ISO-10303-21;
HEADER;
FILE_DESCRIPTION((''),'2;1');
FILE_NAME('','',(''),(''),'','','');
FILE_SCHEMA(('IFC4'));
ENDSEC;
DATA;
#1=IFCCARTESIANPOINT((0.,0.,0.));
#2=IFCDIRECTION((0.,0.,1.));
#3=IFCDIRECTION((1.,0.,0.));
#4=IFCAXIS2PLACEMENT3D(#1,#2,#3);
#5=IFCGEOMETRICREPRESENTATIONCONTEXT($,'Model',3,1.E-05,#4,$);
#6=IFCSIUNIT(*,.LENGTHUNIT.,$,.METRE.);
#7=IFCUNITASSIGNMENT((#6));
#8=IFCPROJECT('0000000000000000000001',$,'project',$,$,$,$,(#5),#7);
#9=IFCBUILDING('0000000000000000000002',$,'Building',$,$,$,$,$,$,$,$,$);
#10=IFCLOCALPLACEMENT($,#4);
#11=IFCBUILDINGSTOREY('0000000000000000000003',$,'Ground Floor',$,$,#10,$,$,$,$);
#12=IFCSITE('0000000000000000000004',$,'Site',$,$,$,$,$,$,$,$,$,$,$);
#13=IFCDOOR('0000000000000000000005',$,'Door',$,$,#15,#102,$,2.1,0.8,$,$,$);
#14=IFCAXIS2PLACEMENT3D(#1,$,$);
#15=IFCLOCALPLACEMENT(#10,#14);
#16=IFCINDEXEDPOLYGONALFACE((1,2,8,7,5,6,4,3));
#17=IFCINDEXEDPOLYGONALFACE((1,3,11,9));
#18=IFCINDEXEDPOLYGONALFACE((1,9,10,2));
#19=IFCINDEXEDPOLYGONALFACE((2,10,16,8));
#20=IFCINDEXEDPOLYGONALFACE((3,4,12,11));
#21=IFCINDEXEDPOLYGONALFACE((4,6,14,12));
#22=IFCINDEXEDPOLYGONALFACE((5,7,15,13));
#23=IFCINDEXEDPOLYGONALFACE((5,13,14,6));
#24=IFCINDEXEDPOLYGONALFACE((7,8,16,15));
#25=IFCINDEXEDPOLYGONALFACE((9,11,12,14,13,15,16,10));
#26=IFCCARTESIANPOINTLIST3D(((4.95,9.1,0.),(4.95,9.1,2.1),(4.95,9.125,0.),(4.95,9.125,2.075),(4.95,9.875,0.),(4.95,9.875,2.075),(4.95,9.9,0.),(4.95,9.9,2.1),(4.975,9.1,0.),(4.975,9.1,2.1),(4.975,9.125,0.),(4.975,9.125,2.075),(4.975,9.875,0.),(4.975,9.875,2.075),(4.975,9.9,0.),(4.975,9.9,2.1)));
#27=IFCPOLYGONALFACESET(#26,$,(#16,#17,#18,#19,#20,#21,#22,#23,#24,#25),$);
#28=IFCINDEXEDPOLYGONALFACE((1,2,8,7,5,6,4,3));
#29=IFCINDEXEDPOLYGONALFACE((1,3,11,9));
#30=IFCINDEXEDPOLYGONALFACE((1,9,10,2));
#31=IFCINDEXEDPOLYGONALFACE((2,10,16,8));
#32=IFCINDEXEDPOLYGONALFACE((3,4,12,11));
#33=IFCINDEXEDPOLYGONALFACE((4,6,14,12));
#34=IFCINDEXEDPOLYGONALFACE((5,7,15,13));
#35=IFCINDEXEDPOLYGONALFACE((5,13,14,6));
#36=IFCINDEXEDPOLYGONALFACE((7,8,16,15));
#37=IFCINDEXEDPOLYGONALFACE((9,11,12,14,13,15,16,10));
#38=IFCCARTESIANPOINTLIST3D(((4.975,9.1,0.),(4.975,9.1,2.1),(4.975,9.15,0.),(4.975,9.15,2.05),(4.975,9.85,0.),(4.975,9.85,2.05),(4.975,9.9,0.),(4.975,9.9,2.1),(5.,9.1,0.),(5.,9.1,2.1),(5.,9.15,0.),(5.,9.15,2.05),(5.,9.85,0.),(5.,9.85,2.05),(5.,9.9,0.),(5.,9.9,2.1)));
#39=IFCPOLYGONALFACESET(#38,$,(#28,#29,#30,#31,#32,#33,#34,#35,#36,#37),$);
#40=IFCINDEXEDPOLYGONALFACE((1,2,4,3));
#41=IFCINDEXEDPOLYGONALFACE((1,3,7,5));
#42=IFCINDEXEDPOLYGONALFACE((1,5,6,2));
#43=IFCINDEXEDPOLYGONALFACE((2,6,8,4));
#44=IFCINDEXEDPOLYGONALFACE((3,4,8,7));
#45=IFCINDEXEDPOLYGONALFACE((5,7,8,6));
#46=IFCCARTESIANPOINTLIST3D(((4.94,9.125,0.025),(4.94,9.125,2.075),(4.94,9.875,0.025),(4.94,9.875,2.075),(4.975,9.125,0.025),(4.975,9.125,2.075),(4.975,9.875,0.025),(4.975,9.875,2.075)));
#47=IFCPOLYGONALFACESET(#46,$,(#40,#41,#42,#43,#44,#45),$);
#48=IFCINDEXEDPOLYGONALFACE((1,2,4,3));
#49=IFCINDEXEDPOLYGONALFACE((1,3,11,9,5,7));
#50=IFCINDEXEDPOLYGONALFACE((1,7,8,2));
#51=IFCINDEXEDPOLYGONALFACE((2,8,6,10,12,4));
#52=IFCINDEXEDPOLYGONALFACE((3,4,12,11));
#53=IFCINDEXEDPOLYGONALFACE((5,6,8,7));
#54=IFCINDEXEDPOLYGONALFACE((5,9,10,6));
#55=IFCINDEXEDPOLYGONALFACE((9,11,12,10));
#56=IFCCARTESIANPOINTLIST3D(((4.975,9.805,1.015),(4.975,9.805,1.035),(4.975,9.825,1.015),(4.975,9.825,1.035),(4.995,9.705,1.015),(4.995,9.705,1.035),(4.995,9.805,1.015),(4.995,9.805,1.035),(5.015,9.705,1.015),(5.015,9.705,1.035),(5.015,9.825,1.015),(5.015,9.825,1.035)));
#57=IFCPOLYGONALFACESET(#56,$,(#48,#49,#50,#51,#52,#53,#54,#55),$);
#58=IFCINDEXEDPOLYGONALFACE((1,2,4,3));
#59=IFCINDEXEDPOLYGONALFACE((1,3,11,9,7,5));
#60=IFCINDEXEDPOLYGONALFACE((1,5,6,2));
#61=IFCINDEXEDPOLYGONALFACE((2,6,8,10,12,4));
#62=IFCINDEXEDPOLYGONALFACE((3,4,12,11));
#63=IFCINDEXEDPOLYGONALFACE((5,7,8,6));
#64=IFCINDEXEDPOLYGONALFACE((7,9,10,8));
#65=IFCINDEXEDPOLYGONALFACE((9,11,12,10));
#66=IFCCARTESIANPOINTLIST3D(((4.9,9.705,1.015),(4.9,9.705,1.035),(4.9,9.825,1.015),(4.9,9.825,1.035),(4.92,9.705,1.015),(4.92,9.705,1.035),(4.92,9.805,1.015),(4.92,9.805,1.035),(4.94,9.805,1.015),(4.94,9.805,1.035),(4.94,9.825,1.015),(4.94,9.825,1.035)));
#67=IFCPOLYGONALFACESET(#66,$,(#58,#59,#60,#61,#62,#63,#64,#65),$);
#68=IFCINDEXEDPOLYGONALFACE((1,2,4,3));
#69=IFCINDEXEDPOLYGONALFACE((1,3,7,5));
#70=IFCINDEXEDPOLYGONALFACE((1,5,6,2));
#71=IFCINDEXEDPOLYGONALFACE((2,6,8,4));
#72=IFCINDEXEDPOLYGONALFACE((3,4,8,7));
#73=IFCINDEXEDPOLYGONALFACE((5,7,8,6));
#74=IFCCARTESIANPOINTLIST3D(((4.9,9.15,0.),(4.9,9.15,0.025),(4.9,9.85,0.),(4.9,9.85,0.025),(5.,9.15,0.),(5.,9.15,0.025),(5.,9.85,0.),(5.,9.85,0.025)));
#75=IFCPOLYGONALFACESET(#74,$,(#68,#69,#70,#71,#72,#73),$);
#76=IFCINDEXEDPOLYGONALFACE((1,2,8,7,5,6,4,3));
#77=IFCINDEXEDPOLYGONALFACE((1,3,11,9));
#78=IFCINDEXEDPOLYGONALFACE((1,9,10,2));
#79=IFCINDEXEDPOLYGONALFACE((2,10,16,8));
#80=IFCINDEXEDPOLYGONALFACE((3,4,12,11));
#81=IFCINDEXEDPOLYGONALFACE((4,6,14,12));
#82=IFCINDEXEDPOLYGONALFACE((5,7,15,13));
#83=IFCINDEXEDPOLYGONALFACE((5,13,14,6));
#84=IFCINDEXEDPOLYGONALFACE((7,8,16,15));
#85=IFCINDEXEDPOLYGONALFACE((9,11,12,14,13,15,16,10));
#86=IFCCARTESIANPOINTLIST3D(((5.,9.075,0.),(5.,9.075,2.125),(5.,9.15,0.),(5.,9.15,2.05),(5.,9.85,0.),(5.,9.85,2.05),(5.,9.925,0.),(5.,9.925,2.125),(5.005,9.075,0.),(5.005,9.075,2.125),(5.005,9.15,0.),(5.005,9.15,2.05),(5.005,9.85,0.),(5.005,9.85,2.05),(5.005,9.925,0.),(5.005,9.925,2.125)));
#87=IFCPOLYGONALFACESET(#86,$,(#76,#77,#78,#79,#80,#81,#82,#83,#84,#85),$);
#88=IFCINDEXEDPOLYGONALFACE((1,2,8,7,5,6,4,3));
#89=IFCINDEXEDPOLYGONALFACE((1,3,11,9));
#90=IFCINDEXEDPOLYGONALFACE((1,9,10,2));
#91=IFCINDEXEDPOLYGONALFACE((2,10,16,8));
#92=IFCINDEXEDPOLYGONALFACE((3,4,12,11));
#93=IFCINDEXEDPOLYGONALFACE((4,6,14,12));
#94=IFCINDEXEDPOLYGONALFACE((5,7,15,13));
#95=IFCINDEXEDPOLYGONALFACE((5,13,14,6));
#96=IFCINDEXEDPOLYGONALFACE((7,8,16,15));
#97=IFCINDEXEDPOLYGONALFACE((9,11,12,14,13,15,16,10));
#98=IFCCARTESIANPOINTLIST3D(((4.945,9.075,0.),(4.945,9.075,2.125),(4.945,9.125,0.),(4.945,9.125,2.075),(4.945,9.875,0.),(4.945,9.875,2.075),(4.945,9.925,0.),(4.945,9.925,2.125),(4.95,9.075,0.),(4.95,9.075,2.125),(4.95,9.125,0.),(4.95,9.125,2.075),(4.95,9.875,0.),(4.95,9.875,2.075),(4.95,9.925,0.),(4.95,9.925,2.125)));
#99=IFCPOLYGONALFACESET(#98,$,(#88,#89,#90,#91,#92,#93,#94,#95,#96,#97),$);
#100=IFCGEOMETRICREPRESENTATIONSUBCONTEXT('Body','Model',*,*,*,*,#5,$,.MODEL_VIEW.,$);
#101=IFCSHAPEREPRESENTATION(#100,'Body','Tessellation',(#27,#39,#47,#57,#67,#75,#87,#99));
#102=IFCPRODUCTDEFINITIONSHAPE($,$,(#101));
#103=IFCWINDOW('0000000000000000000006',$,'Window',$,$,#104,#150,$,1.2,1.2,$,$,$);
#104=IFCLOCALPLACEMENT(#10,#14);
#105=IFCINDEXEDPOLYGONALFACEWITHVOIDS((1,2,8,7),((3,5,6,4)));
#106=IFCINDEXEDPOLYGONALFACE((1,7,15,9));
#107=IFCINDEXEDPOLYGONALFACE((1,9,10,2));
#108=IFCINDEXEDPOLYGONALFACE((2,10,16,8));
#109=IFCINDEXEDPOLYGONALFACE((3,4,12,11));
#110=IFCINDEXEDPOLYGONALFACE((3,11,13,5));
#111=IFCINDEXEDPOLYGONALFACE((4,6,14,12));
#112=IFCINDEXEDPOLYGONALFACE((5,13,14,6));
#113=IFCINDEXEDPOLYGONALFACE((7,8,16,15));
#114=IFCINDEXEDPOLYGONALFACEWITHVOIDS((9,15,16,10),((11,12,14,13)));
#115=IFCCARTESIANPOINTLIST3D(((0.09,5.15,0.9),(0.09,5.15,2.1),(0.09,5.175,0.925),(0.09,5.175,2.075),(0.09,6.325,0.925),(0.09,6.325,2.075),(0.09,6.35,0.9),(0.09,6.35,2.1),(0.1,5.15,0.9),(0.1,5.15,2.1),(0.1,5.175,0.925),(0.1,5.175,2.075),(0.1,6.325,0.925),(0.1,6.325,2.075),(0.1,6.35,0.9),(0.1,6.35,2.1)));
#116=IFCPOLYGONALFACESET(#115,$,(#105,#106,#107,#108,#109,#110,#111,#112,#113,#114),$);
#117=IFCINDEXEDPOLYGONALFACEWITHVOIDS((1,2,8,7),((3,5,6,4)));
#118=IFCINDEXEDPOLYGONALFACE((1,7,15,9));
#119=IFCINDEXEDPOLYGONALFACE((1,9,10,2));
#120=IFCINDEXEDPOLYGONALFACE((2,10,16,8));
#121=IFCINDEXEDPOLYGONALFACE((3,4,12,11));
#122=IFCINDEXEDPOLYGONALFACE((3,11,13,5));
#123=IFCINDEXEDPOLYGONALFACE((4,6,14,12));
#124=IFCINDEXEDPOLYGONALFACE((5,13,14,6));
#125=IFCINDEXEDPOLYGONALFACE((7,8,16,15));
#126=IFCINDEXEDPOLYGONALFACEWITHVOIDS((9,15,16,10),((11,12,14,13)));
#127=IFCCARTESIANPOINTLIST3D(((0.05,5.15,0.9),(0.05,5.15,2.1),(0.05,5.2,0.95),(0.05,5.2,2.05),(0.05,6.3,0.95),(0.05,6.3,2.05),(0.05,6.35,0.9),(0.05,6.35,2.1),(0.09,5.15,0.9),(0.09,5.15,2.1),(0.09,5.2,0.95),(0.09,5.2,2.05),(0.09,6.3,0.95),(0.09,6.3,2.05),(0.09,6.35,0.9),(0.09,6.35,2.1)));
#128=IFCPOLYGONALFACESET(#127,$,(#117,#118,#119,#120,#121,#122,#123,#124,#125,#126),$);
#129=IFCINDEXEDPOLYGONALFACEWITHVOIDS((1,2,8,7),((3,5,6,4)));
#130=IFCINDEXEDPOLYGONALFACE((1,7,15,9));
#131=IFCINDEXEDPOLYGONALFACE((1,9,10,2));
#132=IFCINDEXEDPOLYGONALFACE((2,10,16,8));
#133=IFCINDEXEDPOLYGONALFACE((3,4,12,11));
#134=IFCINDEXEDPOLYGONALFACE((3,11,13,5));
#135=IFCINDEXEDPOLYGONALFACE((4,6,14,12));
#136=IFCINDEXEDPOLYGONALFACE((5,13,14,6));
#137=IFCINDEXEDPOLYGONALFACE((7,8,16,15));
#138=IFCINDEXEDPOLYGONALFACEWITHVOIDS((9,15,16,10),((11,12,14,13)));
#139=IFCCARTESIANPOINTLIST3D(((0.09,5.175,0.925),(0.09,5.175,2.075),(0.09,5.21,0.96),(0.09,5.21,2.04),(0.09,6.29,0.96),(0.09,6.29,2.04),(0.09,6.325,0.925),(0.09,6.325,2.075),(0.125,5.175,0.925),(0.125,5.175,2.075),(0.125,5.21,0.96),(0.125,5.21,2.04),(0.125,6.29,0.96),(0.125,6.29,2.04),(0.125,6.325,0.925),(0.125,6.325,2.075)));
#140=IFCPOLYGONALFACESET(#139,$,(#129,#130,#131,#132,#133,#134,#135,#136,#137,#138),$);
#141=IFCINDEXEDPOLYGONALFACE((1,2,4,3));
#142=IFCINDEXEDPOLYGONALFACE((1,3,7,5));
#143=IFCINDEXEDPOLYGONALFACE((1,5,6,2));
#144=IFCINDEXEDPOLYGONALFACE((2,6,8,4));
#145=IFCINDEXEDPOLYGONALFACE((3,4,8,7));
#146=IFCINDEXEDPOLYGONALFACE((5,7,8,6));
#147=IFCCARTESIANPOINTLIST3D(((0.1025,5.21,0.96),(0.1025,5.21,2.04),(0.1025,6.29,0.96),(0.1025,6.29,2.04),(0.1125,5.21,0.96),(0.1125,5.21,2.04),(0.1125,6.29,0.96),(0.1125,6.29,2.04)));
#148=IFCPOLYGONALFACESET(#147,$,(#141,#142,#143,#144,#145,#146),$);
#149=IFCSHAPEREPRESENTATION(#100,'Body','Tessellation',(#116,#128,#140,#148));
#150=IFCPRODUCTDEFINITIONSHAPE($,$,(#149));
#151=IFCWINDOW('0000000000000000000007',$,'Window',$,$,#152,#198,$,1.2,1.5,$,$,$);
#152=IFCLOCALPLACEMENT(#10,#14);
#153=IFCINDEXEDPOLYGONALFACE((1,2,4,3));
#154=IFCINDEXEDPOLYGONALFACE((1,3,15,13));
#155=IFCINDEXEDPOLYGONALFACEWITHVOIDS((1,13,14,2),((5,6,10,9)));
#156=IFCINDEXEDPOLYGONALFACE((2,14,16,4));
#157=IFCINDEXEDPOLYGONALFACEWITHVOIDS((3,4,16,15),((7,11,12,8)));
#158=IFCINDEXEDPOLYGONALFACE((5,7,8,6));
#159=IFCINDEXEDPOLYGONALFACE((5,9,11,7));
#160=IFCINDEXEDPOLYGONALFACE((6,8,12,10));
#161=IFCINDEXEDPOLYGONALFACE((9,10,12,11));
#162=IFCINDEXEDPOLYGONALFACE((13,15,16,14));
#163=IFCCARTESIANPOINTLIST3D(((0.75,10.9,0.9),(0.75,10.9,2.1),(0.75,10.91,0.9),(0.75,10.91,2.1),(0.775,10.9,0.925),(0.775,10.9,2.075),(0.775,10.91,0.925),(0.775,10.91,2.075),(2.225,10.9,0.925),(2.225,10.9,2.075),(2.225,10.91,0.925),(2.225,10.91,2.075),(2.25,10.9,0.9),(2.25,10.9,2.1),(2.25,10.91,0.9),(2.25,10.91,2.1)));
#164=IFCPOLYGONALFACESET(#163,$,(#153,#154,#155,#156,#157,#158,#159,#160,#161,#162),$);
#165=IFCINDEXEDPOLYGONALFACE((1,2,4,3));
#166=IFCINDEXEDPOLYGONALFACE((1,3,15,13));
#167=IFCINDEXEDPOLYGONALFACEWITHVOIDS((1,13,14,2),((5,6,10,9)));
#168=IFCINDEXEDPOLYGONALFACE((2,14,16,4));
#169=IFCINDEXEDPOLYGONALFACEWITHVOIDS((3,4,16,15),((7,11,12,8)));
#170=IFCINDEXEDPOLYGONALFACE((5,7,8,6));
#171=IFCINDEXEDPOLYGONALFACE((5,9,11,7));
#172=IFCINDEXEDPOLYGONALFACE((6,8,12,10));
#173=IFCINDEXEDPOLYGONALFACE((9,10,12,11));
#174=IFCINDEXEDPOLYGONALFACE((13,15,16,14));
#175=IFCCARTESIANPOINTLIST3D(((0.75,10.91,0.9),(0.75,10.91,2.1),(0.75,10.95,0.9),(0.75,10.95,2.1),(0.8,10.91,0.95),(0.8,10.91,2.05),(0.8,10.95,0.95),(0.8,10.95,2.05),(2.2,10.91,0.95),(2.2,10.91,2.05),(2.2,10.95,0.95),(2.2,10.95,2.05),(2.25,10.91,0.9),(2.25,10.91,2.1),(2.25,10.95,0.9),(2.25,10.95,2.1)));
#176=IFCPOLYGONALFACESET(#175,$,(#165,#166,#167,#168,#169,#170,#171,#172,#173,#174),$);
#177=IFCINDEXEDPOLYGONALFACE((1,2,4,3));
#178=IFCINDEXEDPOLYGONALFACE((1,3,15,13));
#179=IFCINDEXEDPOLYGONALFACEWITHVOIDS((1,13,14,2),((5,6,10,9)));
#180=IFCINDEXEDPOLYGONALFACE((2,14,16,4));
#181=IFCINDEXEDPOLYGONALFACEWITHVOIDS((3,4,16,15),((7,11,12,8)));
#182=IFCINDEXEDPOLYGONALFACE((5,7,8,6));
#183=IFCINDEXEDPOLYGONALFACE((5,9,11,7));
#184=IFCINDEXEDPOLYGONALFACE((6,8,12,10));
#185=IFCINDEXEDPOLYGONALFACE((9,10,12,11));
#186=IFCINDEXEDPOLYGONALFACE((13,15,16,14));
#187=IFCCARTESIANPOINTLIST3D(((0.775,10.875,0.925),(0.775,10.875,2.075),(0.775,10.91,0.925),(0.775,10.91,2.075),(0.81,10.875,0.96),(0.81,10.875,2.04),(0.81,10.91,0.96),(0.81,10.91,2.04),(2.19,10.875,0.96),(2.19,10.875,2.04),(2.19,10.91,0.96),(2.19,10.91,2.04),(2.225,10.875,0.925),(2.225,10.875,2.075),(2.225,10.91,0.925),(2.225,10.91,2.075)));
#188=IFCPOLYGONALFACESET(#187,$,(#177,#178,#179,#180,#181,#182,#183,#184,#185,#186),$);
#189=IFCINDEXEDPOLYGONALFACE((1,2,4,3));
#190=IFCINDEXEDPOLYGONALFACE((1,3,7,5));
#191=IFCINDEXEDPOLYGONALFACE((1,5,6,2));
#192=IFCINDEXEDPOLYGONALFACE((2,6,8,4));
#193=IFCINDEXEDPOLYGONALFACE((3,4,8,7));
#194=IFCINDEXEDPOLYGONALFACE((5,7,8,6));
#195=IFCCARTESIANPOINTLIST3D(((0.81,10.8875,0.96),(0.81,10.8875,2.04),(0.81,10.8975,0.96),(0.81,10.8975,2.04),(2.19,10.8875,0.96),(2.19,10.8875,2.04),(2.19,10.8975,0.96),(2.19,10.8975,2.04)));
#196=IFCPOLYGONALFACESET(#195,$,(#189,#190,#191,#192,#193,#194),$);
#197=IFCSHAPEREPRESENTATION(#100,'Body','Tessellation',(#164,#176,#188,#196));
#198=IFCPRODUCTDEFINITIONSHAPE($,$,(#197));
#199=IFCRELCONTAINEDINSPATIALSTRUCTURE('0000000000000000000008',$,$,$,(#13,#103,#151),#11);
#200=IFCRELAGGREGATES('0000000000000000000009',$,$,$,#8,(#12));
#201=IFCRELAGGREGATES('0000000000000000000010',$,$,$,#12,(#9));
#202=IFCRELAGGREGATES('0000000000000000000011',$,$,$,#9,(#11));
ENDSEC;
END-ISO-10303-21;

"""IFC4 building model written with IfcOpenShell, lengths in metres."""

from ifc_helpers import new_model, si_unit, frame, origin_with_axes, place, context, subcontext, project, spatial, line, indexed_curve, outline, extrude, element, save


model = new_model("IFC4")

# Units and contexts
model_context = context("Model", 3, precision=1e-05, world=origin_with_axes())
body_context = subcontext(model_context, "Body", "Model", "MODEL_VIEW")
ifc_project = project(units=[si_unit("LENGTHUNIT", "METRE")], contexts=[model_context])

# Site, building, storey
site = spatial("IfcSite", under=ifc_project, Name="Site")
building = spatial("IfcBuilding", under=site, Name="Building")
storey_placement = place(None, origin_with_axes())
storey = spatial("IfcBuildingStorey", under=building, at=storey_placement, Name="Ground Floor")

# Door
door_1_placement = place(storey_placement, frame((5.0, 9.1, 0.0), z_axis=(0.0, 0.0, 1.0), x_axis=(0.0, 1.0, 0.0)))
element("IfcDoor", 1, at=door_1_placement, inside=storey, Name="Door", OverallHeight=2.1, OverallWidth=0.8, context=body_context, shape_type="SweptSolid", body=[
    extrude(outline(indexed_curve([(0.0, 0.0), (0.0, 2.1), (0.8, 2.1), (0.8, 0.0), (0.775, 0.0), (0.775, 2.075), (0.025, 2.075), (0.025, 0.0)], segments=[line(1, 2, 3, 4, 5, 6, 7, 8, 1)])), frame((0.0, 0.025, 0.0), z_axis=(0.0, -1.0, 0.0), x_axis=(1.0, 0.0, 0.0)), (0.0, 0.0, -1.0), 0.025),
    extrude(outline(indexed_curve([(0.0, 0.0), (0.0, 2.1), (0.8, 2.1), (0.8, 0.0), (0.75, 0.0), (0.75, 2.05), (0.05, 2.05), (0.05, 0.0)], segments=[line(1, 2, 3, 4, 5, 6, 7, 8, 1)])), frame((0.0, 0.0, 0.0), z_axis=(0.0, -1.0, 0.0), x_axis=(1.0, 0.0, 0.0)), (0.0, 0.0, -1.0), 0.025),
    extrude(outline(indexed_curve([(0.0, 0.0), (0.75, 0.0), (0.75, 0.035), (0.0, 0.035)], segments=[line(1, 2, 3, 4, 1)])), frame((0.025, 0.025, 0.025), z_axis=(0.0, 0.0, 1.0), x_axis=(1.0, 0.0, 0.0)), (0.0, 0.0, 1.0), 2.05),
    extrude(outline(indexed_curve([(0.0, 0.0), (0.0, -0.04), (-0.12, -0.04), (-0.12, -0.02), (-0.02, -0.02), (-0.02, 0.0)], segments=[line(1, 2, 3, 4, 5, 6, 1)])), frame((0.725, 0.025, 1.015), z_axis=(0.0, 0.0, 1.0), x_axis=(1.0, 0.0, 0.0)), (0.0, 0.0, 1.0), 0.02),
    extrude(outline(indexed_curve([(0.0, 0.0), (0.0, 0.04), (-0.12, 0.04), (-0.12, 0.02), (-0.02, 0.02), (-0.02, 0.0)], segments=[line(1, 2, 3, 4, 5, 6, 1)])), frame((0.725, 0.06, 1.015), z_axis=(0.0, 0.0, 1.0), x_axis=(1.0, 0.0, 0.0)), (0.0, 0.0, 1.0), 0.02),
    extrude(outline(indexed_curve([(0.0, 0.0), (0.7, 0.0), (0.7, 0.1), (0.0, 0.1)], segments=[line(1, 2, 3, 4, 1)])), frame((0.05, 0.0, 0.0), z_axis=(0.0, 0.0, 1.0), x_axis=(1.0, 0.0, 0.0)), (0.0, 0.0, 1.0), 0.025),
    extrude(outline(indexed_curve([(0.0, 0.0), (0.0, 2.125), (0.85, 2.125), (0.85, 0.0), (0.775, 0.0), (0.775, 2.05), (0.075, 2.05), (0.075, 0.0)], segments=[line(1, 2, 3, 4, 5, 6, 7, 8, 1)])), frame((-0.025, -0.005, 0.0), z_axis=(0.0, -1.0, 0.0), x_axis=(1.0, 0.0, 0.0)), (0.0, 0.0, -1.0), 0.005),
    extrude(outline(indexed_curve([(0.0, 0.0), (0.0, 2.125), (0.85, 2.125), (0.85, 0.0), (0.8, 0.0), (0.8, 2.075), (0.05, 2.075), (0.05, 0.0)], segments=[line(1, 2, 3, 4, 5, 6, 7, 8, 1)])), frame((-0.025, 0.05, 0.0), z_axis=(0.0, -1.0, 0.0), x_axis=(1.0, 0.0, 0.0)), (0.0, 0.0, -1.0), 0.005),
])

# Windows
window_1_placement = place(storey_placement, frame((0.0, 6.35, 0.9), z_axis=(0.0, 0.0, 1.0), x_axis=(0.0, -1.0, 0.0)))
element("IfcWindow", 2, at=window_1_placement, inside=storey, Name="Window", OverallHeight=1.2, OverallWidth=1.2, context=body_context, shape_type="SweptSolid", body=[
    extrude(outline(indexed_curve([(0.0, 0.0), (1.2, 0.0), (1.2, 1.2), (0.0, 1.2)], segments=[line(1, 2, 3, 4, 1)]), holes=[indexed_curve([(0.025, 0.025), (1.175, 0.025), (1.175, 1.175), (0.025, 1.175)], segments=[line(1, 2, 3, 4, 1)])]), frame((0.0, 0.09, 0.0), z_axis=(0.0, -1.0, 0.0), x_axis=(1.0, 0.0, 0.0)), (0.0, 0.0, -1.0), 0.01),
    extrude(outline(indexed_curve([(0.0, 0.0), (1.2, 0.0), (1.2, 1.2), (0.0, 1.2)], segments=[line(1, 2, 3, 4, 1)]), holes=[indexed_curve([(0.05, 0.05), (1.15, 0.05), (1.15, 1.15), (0.05, 1.15)], segments=[line(1, 2, 3, 4, 1)])]), frame((0.0, 0.05, 0.0), z_axis=(0.0, -1.0, 0.0), x_axis=(1.0, 0.0, 0.0)), (0.0, 0.0, -1.0), 0.04),
    extrude(outline(indexed_curve([(0.0, 0.0), (1.15, 0.0), (1.15, 1.15), (0.0, 1.15)], segments=[line(1, 2, 3, 4, 1)]), holes=[indexed_curve([(0.035, 0.035), (1.115, 0.035), (1.115, 1.115), (0.035, 1.115)], segments=[line(1, 2, 3, 4, 1)])]), frame((0.025, 0.09, 0.025), z_axis=(0.0, -1.0, 0.0), x_axis=(1.0, 0.0, 0.0)), (0.0, 0.0, -1.0), 0.035),
    extrude(outline(indexed_curve([(0.035, 0.035), (1.115, 0.035), (1.115, 1.115), (0.035, 1.115)], segments=[line(1, 2, 3, 4, 1)])), frame((0.025, 0.1025, 0.025), z_axis=(0.0, -1.0, 0.0), x_axis=(1.0, 0.0, 0.0)), (0.0, 0.0, -1.0), 0.01),
])
window_2_placement = place(storey_placement, frame((2.25, 11.0, 0.9), z_axis=(0.0, 0.0, 1.0), x_axis=(-1.0, 0.0, 0.0)))
element("IfcWindow", 3, at=window_2_placement, inside=storey, Name="Window", OverallHeight=1.2, OverallWidth=1.5, context=body_context, shape_type="SweptSolid", body=[
    extrude(outline(indexed_curve([(0.0, 0.0), (1.5, 0.0), (1.5, 1.2), (0.0, 1.2)], segments=[line(1, 2, 3, 4, 1)]), holes=[indexed_curve([(0.025, 0.025), (1.475, 0.025), (1.475, 1.175), (0.025, 1.175)], segments=[line(1, 2, 3, 4, 1)])]), frame((0.0, 0.09, 0.0), z_axis=(0.0, -1.0, 0.0), x_axis=(1.0, 0.0, 0.0)), (0.0, 0.0, -1.0), 0.01),
    extrude(outline(indexed_curve([(0.0, 0.0), (1.5, 0.0), (1.5, 1.2), (0.0, 1.2)], segments=[line(1, 2, 3, 4, 1)]), holes=[indexed_curve([(0.05, 0.05), (1.45, 0.05), (1.45, 1.15), (0.05, 1.15)], segments=[line(1, 2, 3, 4, 1)])]), frame((0.0, 0.05, 0.0), z_axis=(0.0, -1.0, 0.0), x_axis=(1.0, 0.0, 0.0)), (0.0, 0.0, -1.0), 0.04),
    extrude(outline(indexed_curve([(0.0, 0.0), (1.45, 0.0), (1.45, 1.15), (0.0, 1.15)], segments=[line(1, 2, 3, 4, 1)]), holes=[indexed_curve([(0.035, 0.035), (1.415, 0.035), (1.415, 1.115), (0.035, 1.115)], segments=[line(1, 2, 3, 4, 1)])]), frame((0.025, 0.09, 0.025), z_axis=(0.0, -1.0, 0.0), x_axis=(1.0, 0.0, 0.0)), (0.0, 0.0, -1.0), 0.035),
    extrude(outline(indexed_curve([(0.035, 0.035), (1.415, 0.035), (1.415, 1.115), (0.035, 1.115)], segments=[line(1, 2, 3, 4, 1)])), frame((0.025, 0.1025, 0.025), z_axis=(0.0, -1.0, 0.0), x_axis=(1.0, 0.0, 0.0)), (0.0, 0.0, -1.0), 0.01),
])

save(model, "model.ifc")
